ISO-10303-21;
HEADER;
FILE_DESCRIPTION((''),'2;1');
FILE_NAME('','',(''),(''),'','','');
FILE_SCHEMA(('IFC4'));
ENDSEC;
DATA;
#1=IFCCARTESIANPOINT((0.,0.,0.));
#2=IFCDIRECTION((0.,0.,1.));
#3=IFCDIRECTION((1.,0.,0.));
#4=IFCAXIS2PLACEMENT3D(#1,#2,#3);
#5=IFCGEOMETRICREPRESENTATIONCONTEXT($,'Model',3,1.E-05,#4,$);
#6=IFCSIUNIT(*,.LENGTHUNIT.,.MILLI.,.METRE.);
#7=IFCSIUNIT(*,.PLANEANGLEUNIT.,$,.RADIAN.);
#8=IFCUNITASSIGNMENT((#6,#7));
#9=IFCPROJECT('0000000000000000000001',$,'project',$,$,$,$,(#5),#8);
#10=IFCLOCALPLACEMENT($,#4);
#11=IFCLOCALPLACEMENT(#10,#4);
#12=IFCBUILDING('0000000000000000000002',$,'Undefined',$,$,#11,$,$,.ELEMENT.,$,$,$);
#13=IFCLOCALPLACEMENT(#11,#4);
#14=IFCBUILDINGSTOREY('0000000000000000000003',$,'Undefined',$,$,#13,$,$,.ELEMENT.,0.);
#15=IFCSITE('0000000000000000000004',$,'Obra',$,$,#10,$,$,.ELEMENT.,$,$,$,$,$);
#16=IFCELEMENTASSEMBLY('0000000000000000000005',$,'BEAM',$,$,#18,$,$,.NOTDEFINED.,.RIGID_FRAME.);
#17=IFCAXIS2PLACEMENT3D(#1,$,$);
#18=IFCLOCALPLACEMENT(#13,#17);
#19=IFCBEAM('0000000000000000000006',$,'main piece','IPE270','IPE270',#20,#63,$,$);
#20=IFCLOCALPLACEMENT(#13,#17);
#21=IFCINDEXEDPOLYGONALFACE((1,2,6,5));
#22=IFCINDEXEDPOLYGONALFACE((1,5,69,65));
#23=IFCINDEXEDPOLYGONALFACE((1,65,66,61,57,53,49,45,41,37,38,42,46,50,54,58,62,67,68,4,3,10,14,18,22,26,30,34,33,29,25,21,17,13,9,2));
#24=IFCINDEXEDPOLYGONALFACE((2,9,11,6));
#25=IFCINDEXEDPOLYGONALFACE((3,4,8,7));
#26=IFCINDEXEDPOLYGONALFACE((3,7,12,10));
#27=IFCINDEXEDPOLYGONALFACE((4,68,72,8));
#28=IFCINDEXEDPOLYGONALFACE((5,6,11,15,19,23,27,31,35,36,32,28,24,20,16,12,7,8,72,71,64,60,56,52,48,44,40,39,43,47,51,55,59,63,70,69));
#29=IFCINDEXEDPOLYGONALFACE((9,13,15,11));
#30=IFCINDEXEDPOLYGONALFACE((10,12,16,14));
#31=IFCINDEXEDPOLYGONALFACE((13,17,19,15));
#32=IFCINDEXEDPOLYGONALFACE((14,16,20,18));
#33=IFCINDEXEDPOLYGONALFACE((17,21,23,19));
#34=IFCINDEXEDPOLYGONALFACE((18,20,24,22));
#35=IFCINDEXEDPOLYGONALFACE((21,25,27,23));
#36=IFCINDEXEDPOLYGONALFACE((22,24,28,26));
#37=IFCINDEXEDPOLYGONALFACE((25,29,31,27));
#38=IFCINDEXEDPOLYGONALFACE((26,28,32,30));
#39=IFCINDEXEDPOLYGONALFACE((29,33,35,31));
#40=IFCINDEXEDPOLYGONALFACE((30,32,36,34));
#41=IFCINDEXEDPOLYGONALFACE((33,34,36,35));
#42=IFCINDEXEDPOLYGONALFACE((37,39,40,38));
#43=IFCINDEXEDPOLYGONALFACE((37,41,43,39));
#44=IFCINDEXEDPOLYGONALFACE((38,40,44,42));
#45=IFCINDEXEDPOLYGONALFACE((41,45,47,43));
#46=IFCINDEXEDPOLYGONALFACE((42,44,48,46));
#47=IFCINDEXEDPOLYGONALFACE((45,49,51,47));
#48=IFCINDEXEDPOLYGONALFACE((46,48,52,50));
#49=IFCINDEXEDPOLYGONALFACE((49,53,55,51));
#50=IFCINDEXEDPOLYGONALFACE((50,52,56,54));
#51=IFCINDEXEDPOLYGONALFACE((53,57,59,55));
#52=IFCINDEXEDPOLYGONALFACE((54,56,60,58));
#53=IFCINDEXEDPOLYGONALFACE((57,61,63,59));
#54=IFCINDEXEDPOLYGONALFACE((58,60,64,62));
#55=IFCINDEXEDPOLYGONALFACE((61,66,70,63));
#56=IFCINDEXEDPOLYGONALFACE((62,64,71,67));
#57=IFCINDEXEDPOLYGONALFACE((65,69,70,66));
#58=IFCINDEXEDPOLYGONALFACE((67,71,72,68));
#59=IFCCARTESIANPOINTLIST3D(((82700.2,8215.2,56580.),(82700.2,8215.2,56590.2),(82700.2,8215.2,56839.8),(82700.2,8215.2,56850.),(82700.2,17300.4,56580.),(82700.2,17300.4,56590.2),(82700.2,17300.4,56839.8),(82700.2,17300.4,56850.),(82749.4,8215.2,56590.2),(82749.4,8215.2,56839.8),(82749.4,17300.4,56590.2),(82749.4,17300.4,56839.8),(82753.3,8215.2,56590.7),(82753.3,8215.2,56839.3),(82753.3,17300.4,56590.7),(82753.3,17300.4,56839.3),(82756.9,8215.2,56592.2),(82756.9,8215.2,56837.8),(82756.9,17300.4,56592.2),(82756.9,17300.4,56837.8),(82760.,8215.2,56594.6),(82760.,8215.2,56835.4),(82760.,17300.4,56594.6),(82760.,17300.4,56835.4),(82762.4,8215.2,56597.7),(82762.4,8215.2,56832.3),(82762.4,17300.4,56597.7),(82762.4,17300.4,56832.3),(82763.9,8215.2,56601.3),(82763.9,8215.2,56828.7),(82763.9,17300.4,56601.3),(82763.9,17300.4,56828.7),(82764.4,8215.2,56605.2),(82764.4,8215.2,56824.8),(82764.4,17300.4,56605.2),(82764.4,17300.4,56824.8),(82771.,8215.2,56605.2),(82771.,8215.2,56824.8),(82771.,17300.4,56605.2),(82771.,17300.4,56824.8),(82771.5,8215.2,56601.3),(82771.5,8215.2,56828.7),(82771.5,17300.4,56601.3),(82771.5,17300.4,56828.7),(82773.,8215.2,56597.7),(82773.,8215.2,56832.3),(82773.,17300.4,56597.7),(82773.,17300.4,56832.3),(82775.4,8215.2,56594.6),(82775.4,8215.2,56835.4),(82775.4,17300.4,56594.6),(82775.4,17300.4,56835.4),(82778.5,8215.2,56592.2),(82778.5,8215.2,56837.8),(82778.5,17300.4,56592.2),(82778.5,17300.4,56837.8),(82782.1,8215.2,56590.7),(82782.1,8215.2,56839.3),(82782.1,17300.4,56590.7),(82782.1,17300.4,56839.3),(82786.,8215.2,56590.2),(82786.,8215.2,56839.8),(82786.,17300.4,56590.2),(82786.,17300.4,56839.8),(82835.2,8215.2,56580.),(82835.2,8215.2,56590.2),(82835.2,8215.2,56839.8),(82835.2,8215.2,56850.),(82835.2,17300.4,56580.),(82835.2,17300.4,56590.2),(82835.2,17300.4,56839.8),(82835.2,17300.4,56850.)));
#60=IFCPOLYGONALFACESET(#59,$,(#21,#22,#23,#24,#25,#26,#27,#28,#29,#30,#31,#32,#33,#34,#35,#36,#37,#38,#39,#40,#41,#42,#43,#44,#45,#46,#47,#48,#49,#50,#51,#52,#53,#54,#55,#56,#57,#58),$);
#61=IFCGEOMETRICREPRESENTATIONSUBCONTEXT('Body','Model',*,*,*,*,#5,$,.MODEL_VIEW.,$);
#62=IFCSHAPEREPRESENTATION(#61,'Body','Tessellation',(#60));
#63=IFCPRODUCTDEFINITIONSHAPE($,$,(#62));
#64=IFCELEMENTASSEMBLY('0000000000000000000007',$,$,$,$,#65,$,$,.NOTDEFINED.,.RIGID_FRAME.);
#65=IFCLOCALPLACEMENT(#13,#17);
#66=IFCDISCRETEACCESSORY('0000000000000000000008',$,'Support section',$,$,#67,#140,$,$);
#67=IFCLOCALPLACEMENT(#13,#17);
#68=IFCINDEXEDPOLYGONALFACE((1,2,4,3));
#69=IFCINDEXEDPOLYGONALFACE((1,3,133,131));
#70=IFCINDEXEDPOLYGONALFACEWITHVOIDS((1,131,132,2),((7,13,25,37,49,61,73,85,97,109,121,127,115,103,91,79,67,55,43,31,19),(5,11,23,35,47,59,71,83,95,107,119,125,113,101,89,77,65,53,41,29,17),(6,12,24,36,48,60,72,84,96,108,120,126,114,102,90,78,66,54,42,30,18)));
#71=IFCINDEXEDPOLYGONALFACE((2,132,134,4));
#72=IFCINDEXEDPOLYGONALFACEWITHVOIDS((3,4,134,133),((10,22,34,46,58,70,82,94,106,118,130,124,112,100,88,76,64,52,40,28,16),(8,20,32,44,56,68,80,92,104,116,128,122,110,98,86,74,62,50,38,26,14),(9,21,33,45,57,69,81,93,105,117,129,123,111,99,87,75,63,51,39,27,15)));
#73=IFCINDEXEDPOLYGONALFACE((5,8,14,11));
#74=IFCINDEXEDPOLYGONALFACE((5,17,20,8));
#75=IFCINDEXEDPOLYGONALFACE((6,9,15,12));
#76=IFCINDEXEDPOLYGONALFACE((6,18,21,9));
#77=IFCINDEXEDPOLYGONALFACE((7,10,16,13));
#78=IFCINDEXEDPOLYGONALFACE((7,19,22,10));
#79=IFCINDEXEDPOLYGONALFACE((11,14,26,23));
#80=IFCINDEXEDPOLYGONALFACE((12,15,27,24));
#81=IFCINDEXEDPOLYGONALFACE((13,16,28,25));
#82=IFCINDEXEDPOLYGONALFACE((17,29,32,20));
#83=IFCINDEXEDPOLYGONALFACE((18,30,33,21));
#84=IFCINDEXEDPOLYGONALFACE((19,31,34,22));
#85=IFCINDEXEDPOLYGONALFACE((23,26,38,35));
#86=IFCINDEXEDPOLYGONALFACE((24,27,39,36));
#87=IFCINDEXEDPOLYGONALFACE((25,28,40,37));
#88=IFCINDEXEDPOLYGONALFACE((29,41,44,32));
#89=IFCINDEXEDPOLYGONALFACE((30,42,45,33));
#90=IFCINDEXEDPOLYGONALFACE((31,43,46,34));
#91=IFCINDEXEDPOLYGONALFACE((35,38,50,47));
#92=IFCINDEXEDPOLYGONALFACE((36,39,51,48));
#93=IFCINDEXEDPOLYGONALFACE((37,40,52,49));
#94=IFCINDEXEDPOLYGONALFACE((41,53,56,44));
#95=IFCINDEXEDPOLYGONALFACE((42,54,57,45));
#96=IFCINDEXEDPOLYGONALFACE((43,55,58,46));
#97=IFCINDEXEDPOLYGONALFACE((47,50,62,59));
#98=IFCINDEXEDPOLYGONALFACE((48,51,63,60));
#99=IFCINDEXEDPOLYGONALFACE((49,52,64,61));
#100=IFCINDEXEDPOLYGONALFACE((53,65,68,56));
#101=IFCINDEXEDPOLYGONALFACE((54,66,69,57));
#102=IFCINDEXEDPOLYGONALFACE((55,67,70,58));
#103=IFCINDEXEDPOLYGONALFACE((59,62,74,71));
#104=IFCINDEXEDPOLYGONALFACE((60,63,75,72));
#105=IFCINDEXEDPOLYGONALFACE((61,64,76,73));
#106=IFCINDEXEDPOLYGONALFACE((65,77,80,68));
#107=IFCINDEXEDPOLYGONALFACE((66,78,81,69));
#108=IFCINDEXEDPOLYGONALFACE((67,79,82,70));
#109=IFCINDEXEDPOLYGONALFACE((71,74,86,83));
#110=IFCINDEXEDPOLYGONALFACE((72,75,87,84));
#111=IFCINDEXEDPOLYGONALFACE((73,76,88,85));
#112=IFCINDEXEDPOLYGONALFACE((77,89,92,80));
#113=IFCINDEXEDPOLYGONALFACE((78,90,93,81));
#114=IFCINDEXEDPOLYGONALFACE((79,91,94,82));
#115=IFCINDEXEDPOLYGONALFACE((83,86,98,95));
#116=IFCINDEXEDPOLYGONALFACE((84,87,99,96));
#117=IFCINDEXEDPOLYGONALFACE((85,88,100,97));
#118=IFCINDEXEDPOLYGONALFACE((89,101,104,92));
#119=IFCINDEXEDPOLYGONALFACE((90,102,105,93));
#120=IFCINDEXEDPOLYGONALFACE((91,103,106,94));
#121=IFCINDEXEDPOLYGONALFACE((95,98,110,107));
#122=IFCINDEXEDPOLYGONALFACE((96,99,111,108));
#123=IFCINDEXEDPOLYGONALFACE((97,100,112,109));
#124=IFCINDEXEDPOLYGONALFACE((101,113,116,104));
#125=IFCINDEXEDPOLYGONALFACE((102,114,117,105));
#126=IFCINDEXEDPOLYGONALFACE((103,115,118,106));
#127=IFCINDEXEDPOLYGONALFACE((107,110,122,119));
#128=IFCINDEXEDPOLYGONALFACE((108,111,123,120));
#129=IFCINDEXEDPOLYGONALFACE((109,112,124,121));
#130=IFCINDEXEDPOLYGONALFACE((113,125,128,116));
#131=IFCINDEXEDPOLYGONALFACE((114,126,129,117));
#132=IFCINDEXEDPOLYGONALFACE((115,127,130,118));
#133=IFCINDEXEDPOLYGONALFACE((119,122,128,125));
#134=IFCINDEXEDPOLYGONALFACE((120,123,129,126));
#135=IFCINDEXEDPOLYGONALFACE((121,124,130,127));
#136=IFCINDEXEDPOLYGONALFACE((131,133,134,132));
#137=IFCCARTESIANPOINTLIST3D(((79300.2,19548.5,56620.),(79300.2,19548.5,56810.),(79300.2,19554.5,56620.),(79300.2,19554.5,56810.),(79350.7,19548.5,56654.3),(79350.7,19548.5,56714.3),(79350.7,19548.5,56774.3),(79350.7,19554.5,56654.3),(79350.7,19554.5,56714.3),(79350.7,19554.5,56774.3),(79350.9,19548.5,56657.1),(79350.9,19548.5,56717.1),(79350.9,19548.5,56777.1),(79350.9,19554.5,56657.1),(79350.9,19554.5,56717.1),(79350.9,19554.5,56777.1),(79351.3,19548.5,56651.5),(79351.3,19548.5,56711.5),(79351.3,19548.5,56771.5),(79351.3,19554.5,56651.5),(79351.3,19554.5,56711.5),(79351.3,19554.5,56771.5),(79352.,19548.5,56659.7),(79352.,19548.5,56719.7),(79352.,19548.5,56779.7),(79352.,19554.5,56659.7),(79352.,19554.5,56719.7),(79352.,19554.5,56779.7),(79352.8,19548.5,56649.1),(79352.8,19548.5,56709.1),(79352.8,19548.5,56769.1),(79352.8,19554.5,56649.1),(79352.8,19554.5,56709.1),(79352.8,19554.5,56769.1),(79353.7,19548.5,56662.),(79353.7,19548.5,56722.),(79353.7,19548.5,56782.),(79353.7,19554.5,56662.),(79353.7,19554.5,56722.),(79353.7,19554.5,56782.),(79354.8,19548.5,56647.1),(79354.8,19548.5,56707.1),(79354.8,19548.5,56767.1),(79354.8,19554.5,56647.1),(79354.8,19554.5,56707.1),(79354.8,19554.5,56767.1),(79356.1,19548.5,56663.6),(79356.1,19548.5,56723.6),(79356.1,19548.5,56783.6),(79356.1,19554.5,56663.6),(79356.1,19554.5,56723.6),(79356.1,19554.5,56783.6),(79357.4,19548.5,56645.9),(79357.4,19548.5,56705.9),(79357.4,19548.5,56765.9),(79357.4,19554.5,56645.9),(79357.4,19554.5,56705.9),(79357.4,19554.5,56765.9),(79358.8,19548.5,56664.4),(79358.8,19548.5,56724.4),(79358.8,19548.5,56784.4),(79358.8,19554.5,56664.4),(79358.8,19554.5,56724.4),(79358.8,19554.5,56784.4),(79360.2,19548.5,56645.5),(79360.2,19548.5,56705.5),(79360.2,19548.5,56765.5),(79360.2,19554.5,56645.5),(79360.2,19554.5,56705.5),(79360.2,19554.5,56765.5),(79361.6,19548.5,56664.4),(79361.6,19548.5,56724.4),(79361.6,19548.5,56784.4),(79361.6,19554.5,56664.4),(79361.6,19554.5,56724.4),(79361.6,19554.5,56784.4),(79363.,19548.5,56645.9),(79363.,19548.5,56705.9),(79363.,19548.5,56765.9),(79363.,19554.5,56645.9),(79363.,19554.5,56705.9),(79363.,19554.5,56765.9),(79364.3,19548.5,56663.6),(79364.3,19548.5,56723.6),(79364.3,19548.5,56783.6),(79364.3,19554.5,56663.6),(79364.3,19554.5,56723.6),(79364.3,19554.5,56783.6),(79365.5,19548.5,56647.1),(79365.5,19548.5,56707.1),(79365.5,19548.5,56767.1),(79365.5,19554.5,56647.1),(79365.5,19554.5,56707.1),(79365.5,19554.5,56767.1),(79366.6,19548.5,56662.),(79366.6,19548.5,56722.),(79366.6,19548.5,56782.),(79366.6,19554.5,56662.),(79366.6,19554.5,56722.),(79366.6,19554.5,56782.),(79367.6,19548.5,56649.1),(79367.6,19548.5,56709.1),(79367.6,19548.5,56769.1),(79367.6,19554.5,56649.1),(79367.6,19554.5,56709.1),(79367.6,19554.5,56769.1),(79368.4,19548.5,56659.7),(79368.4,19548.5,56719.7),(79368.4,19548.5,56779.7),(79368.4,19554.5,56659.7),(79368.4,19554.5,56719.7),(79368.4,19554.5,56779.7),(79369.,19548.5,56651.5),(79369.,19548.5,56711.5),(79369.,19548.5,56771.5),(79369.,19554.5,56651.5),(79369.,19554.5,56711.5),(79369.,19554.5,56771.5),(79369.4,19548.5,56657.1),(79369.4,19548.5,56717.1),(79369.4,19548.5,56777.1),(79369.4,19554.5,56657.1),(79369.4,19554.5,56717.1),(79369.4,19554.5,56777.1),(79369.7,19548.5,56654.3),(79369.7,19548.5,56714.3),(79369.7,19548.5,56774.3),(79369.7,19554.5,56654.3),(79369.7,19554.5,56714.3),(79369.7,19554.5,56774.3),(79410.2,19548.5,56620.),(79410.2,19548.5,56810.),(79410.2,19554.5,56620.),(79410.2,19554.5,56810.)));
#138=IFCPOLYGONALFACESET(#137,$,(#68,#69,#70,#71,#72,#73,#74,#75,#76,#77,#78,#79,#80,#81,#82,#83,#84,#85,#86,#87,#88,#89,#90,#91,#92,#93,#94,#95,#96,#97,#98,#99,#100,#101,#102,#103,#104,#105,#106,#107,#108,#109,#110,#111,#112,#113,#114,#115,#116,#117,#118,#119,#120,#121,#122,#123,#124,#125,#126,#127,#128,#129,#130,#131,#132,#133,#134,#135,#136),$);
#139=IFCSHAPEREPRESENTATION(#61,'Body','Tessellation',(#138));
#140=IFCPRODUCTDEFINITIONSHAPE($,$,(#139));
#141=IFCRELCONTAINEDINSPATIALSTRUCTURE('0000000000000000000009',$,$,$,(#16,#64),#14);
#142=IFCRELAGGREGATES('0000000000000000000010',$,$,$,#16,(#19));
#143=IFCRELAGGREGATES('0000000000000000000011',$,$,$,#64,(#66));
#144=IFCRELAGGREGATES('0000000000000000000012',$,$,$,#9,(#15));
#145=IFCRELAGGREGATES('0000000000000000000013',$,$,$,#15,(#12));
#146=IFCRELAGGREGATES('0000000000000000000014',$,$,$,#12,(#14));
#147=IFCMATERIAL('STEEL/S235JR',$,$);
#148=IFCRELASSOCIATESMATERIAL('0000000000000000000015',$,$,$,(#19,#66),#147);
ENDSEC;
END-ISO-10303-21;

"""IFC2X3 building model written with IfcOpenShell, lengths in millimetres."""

from ifc_helpers import new_model, si_unit, frame, origin_with_axes, origin_2d_with_axis, place, context, subcontext, project, spatial, rectangle, circle, i_section, extrude, source, transform, mapped, material, element, aggregate, save


model = new_model("IFC2X3")

# Units and contexts
model_context = context("Model", 3, precision=1e-05, world=origin_with_axes())
body_context = subcontext(model_context, "Body", "Model", "MODEL_VIEW")
ifc_project = project(units=[si_unit("LENGTHUNIT", "METRE", prefix="MILLI"), si_unit("PLANEANGLEUNIT", "RADIAN")], contexts=[model_context])

# Site, building, storey
site_placement = place(None, origin_with_axes())
site = spatial("IfcSite", under=ifc_project, at=site_placement, Name="Obra", CompositionType="ELEMENT")
building_placement = place(site_placement, origin_with_axes())
building = spatial("IfcBuilding", under=site, at=building_placement, Name="Undefined", CompositionType="ELEMENT")
storey_placement = place(building_placement, origin_with_axes())
storey = spatial("IfcBuildingStorey", under=building, at=storey_placement, Name="Undefined", CompositionType="ELEMENT", Elevation=0.0)

# Shared definitions
ifc_material = material(Name="STEEL/S235JR")

# Element assembly, beam
assembly_1_placement = place(storey_placement, origin_with_axes())
assembly_1 = element("IfcElementAssembly", 1, at=assembly_1_placement, inside=storey, Name="BEAM", AssemblyPlace="NOTDEFINED", PredefinedType="RIGID_FRAME")
beam_1_placement = place(assembly_1_placement, frame((82767.7, 17300.4, 56715.0), z_axis=(0.0, 0.0, 1.0), x_axis=(0.0, -1.0, 0.0)))
beam_1 = element("IfcBeam", 2, at=beam_1_placement, material=ifc_material, Name="main piece", Description="IPE270", ObjectType="IPE270", context=body_context, shape_type="SweptSolid", body=[
    extrude(i_section(OverallWidth=135.0, OverallDepth=270.0, WebThickness=6.6, FlangeThickness=10.2, FilletRadius=15.0, at=origin_2d_with_axis()), frame((9085.2, 0.0, 0.0), z_axis=(-1.0, 0.0, 0.0), x_axis=(0.0, -1.0, 0.0)), (0.0, 0.0, 1.0), 9085.2),
])
aggregate(assembly_1, [beam_1])

# Element assembly, discrete accessory, opening
assembly_2_placement = place(storey_placement, origin_with_axes())
assembly_2 = element("IfcElementAssembly", 3, at=assembly_2_placement, inside=storey, AssemblyPlace="NOTDEFINED", PredefinedType="RIGID_FRAME")
discrete_accessory_1_placement = place(assembly_2_placement, frame((79355.2, 19551.5, 56620.0), z_axis=(0.0, 0.0, 1.0), x_axis=(-1.0, 0.0, 0.0)))
discrete_accessory_1 = element("IfcDiscreteAccessory", 4, at=discrete_accessory_1_placement, material=ifc_material, Name="Support section", context=body_context, shape_type="SweptSolid", body=[
    extrude(rectangle(XDim=6.0, YDim=110.0, at=origin_2d_with_axis()), frame((0.0, 0.0, 190.0), z_axis=(0.0, 0.0, -1.0), x_axis=(0.0, 1.0, 0.0)), (0.0, 0.0, 1.0), 190.0),
])
shared_shape_1 = source(origin_with_axes(), body_context, "Body", "SweptSolid", [
    extrude(circle(Radius=9.5, at=origin_2d_with_axis()), frame((0.0, -9.2, 0.0), z_axis=(0.0, 1.0, 0.0), x_axis=(1.0, 0.0, 0.0)), (0.0, 0.0, 1.0), 6.2),
])
opening_1_placement = place(assembly_2_placement, frame((79310.2, 19557.6, 56835.0), z_axis=(1.0, 0.0, 0.0), x_axis=(0.0, 0.0, -1.0)))
element("IfcOpeningElement", 5, at=opening_1_placement, cuts=discrete_accessory_1, ObjectType="Opening", context=body_context, shape_type="MappedRepresentation", body=[
    mapped(shared_shape_1, transform((60.0, 0.0, 50.0))),
    mapped(shared_shape_1, transform((120.0, 0.0, 50.0))),
    mapped(shared_shape_1, transform((180.0, 0.0, 50.0))),
])
aggregate(assembly_2, [discrete_accessory_1])

save(model, "model.ifc")
